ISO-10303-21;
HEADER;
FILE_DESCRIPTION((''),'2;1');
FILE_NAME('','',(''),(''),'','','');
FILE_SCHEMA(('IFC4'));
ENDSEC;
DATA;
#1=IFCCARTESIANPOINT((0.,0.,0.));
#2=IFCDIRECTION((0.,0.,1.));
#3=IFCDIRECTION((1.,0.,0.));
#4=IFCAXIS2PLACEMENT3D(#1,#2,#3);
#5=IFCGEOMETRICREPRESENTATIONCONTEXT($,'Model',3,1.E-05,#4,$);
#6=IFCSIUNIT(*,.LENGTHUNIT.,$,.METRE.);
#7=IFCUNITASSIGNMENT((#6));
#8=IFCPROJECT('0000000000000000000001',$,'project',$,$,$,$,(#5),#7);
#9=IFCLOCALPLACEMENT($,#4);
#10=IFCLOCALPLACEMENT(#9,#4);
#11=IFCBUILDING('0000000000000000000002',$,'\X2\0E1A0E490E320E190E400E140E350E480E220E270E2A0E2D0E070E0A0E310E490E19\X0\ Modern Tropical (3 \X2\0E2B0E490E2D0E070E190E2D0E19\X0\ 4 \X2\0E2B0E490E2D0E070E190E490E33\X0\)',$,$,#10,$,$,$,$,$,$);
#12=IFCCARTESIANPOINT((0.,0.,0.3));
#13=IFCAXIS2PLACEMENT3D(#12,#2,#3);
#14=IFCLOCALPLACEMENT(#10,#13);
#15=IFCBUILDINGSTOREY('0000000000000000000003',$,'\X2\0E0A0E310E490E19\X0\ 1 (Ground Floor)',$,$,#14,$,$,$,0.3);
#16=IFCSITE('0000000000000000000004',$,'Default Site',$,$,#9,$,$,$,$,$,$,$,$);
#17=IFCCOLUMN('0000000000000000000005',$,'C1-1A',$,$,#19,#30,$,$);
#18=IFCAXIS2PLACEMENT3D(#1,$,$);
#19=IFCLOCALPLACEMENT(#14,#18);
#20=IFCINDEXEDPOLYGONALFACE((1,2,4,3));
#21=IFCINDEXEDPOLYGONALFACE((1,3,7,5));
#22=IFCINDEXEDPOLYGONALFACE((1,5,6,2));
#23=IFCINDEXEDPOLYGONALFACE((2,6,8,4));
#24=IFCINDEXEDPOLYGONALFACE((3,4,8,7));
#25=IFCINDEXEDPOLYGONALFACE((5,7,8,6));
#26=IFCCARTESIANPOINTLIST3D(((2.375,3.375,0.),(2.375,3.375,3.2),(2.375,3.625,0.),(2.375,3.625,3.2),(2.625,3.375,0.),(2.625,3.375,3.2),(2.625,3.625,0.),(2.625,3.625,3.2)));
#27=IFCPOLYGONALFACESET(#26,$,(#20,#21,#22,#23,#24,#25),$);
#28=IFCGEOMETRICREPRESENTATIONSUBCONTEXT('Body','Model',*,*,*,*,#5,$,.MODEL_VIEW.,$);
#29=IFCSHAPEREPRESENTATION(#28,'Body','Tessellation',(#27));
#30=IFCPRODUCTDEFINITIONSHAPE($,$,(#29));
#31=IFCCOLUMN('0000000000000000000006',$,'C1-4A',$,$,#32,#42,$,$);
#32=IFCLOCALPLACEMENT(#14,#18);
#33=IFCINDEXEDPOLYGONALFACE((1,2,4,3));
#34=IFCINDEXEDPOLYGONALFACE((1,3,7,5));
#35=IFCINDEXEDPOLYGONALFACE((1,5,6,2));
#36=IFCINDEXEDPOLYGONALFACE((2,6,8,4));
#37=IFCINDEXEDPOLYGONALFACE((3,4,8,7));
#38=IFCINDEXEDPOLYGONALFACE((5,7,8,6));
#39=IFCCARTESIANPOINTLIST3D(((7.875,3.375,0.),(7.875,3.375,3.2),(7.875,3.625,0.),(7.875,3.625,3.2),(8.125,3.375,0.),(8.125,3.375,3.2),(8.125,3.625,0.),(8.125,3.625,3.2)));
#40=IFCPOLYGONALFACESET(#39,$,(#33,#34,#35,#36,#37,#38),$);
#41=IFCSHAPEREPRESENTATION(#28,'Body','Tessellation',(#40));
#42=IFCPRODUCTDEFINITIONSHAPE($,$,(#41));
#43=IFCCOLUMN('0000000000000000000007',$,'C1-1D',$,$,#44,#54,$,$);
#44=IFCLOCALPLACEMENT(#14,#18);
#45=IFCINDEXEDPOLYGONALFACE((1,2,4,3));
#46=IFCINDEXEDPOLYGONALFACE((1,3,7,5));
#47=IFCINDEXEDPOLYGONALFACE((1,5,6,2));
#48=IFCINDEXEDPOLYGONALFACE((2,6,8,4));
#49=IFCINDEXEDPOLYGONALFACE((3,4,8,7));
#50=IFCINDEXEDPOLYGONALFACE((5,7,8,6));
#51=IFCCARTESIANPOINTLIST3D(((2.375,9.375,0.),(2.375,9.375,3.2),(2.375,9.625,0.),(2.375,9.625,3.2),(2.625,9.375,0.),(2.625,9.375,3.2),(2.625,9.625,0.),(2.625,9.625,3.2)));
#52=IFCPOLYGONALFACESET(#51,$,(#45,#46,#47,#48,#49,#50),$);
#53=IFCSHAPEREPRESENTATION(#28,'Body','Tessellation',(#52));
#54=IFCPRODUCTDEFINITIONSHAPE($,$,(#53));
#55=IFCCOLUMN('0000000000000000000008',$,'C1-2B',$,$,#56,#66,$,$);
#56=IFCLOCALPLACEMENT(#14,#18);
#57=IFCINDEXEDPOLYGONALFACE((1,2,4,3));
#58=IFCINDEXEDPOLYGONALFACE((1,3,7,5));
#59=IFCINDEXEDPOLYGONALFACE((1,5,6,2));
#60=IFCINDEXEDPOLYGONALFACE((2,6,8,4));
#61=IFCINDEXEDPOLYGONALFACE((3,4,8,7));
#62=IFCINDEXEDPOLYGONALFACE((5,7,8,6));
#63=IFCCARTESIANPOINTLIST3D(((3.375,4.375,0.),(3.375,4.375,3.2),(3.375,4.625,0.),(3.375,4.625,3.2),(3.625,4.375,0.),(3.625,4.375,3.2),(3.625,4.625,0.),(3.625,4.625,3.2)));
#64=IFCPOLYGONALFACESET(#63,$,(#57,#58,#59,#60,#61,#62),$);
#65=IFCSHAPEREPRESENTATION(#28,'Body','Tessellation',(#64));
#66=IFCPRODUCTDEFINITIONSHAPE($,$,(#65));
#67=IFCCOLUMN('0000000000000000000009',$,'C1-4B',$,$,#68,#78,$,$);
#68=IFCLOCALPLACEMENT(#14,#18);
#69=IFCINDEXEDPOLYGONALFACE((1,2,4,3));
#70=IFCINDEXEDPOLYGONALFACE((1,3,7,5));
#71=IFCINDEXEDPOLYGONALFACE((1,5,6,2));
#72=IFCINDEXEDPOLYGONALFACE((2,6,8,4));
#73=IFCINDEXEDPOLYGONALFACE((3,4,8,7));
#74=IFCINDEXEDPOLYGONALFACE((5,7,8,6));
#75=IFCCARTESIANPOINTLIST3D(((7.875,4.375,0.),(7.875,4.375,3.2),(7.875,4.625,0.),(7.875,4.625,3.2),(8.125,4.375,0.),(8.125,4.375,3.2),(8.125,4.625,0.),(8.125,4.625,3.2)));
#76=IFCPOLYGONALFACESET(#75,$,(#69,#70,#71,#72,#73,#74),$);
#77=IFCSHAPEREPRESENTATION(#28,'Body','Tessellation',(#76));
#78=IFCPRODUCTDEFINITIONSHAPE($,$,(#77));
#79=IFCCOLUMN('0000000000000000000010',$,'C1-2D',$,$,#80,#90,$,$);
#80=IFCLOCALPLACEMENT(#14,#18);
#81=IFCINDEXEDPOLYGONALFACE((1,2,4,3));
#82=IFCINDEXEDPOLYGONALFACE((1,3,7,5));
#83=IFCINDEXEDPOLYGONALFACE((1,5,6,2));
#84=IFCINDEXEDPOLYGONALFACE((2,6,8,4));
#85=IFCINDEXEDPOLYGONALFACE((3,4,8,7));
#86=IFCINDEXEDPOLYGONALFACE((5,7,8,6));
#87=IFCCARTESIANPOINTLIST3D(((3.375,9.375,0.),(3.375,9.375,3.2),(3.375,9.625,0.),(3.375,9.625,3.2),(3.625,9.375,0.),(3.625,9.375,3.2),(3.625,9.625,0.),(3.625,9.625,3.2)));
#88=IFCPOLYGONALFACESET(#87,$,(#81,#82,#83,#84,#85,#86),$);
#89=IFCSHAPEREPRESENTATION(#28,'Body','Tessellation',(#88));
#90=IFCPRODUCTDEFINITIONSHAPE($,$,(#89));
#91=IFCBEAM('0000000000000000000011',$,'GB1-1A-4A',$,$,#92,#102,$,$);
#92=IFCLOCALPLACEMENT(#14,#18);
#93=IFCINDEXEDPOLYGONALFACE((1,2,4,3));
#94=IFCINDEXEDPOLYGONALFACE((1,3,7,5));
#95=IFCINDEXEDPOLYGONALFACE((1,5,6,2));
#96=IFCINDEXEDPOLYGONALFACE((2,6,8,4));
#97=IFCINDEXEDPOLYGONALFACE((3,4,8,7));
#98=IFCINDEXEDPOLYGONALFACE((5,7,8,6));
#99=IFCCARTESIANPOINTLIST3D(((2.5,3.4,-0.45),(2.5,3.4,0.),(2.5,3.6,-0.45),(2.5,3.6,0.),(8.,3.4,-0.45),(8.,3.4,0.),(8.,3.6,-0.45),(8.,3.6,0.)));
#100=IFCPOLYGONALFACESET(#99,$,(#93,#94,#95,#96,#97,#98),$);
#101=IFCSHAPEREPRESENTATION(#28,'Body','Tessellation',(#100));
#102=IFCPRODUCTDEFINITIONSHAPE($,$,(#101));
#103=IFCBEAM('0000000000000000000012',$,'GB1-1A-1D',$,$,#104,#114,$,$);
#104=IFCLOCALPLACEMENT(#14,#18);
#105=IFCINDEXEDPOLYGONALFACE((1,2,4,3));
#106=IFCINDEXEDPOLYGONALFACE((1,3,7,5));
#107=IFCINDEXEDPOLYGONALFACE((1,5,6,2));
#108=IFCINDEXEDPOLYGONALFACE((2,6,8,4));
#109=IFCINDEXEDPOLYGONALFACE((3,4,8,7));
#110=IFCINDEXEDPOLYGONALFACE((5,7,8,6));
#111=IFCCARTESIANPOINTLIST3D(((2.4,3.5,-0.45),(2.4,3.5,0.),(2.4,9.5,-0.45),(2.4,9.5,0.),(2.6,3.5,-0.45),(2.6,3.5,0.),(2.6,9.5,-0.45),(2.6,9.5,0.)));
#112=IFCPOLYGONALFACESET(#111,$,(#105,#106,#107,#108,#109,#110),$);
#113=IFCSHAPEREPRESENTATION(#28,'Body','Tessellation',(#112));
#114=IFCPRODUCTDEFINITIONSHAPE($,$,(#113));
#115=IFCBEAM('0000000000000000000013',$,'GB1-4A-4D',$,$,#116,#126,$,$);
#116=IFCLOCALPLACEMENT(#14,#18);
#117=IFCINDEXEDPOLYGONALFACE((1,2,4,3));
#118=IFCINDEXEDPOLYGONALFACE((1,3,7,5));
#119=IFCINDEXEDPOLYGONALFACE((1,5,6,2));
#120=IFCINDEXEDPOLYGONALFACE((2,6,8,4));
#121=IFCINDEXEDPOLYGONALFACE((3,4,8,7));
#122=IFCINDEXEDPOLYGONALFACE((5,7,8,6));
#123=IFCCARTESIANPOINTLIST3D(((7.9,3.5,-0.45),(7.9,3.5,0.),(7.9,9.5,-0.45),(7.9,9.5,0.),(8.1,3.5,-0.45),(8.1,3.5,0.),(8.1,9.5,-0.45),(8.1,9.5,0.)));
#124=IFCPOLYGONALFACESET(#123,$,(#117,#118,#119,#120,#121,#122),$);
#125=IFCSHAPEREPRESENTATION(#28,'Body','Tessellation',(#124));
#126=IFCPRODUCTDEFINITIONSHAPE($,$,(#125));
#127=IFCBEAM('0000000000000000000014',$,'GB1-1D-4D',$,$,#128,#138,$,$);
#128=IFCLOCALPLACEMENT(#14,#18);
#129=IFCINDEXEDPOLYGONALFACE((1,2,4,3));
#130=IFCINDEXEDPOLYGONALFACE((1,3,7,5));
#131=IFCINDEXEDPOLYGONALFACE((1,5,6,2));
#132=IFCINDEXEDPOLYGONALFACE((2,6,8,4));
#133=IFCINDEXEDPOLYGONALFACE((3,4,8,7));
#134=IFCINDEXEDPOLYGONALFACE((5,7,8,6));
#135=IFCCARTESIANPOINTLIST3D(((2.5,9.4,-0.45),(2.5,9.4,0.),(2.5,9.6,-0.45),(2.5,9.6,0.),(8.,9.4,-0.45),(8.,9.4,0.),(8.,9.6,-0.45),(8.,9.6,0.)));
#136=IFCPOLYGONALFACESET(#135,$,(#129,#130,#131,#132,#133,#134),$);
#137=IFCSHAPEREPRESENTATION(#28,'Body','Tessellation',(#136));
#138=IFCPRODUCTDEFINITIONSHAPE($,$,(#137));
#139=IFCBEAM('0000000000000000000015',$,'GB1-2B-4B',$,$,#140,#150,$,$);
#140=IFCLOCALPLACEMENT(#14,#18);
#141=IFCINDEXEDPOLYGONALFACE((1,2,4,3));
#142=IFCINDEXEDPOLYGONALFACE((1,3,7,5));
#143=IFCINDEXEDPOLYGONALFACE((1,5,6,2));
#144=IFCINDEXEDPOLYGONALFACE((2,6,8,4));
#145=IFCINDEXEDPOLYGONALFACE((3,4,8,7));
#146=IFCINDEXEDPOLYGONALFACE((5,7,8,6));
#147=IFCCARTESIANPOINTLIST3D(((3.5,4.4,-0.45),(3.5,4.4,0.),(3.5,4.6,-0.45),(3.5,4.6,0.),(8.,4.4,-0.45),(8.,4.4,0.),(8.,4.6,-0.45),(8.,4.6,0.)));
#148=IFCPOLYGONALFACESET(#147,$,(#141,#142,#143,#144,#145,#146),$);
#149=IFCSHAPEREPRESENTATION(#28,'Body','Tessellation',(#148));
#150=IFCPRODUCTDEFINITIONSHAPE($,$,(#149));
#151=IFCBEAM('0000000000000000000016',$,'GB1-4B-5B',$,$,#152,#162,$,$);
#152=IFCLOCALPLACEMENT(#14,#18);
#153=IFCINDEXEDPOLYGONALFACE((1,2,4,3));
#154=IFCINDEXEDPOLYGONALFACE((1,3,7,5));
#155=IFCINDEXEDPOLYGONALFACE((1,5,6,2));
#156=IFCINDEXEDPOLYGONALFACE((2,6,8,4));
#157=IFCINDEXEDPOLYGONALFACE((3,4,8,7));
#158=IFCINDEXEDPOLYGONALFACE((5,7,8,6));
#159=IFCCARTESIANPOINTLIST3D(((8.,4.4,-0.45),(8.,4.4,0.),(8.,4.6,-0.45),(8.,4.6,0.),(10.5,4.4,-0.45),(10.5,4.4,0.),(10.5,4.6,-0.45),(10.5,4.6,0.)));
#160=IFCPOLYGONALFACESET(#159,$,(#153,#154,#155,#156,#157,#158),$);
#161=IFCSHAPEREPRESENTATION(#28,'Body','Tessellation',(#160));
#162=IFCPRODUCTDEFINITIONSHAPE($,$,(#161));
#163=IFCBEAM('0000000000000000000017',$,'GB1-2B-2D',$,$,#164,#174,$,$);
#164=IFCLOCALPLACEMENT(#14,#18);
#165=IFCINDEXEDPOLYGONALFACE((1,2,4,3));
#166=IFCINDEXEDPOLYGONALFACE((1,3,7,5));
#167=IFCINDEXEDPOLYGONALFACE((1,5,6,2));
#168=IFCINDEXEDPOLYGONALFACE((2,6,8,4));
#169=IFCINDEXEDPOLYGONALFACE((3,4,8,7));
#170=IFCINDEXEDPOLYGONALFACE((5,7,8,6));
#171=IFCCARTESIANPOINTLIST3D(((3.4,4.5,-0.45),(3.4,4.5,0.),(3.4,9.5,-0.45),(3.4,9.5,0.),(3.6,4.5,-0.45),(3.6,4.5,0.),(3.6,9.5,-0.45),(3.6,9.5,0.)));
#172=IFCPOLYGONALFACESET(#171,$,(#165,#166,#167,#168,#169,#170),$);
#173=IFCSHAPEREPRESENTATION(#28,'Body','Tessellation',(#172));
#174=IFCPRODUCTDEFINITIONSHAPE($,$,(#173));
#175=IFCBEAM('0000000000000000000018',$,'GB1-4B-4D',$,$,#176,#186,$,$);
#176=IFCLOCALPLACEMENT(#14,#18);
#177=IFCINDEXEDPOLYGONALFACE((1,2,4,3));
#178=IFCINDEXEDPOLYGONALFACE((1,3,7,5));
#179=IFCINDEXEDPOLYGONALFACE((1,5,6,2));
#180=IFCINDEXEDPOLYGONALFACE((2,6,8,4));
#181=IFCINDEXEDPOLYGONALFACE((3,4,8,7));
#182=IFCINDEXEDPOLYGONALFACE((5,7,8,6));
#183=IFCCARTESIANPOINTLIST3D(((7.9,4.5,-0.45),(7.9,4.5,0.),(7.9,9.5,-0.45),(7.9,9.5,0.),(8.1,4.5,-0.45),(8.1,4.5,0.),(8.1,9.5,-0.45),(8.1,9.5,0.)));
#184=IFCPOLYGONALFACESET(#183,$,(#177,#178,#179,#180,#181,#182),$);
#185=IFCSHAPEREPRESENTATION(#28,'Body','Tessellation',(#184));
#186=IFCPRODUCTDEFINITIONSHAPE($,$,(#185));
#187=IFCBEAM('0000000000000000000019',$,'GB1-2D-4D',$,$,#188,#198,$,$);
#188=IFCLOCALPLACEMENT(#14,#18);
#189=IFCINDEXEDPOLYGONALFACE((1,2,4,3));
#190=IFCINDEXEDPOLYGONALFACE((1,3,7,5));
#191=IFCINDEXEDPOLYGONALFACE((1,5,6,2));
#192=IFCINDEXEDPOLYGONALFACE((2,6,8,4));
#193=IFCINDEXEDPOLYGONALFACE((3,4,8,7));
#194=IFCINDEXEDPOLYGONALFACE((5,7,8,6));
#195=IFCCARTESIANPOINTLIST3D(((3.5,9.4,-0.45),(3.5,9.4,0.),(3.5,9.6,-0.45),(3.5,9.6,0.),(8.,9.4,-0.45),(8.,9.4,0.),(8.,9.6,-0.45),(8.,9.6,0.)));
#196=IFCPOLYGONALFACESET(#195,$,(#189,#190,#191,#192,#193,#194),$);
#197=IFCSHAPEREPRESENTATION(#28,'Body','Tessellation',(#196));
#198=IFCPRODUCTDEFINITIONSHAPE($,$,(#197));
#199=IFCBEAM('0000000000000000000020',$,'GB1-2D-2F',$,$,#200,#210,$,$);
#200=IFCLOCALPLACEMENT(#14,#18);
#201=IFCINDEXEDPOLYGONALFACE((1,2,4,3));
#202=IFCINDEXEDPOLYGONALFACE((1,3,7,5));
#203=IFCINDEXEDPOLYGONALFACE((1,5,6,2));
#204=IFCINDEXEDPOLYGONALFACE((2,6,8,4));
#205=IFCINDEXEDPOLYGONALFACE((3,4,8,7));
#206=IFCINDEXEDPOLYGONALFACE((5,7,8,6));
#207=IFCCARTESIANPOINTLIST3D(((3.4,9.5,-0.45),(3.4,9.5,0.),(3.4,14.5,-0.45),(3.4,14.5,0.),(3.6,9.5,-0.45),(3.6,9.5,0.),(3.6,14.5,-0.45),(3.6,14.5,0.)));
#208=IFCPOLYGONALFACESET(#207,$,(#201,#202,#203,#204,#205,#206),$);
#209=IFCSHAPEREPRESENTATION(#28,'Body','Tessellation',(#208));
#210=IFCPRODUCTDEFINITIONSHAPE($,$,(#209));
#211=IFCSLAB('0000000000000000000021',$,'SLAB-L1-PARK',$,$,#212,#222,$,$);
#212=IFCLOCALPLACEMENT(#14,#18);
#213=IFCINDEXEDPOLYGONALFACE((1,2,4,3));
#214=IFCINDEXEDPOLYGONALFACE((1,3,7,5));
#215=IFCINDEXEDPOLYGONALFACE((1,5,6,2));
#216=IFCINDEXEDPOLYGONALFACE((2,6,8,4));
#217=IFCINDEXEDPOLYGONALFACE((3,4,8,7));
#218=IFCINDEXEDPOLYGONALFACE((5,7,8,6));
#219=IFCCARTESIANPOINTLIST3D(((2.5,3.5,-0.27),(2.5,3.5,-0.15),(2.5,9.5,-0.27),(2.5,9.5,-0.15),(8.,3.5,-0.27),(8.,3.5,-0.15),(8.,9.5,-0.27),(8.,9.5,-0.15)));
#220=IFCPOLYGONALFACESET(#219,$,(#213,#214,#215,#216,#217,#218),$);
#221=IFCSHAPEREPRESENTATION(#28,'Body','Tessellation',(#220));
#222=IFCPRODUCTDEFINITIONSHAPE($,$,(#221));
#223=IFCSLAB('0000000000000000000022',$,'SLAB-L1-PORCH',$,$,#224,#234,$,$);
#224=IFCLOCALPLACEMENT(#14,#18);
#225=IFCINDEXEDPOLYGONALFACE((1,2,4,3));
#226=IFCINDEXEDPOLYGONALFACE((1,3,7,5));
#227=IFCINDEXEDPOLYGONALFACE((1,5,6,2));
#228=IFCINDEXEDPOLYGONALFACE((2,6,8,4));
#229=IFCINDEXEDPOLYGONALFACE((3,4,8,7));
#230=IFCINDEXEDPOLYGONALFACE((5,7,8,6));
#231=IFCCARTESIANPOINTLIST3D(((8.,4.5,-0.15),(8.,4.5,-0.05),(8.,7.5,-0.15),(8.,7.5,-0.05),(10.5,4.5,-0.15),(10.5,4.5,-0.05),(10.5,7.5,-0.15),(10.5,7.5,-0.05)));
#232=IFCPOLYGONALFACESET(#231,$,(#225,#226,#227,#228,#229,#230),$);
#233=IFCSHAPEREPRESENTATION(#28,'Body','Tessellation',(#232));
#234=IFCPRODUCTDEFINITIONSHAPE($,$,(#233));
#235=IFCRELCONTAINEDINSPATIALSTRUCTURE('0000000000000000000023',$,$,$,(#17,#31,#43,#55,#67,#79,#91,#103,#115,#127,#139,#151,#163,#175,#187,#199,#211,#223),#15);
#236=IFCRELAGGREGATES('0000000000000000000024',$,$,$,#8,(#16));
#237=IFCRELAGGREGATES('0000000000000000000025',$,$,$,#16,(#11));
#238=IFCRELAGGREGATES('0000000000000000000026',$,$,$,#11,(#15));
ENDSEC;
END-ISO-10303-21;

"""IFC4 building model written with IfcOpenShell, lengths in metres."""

from ifc_helpers import new_model, si_unit, frame, origin_with_axes, origin_2d, place, context, subcontext, project, spatial, polyline, rectangle, outline, extrude, element, save


model = new_model("IFC4")

# Units and contexts
model_context = context("Model", 3, precision=1e-05, world=origin_with_axes())
body_context = subcontext(model_context, "Body", "Model", "MODEL_VIEW")
ifc_project = project(units=[si_unit("LENGTHUNIT", "METRE")], contexts=[model_context])

# Site, building, storey
site_placement = place(None, origin_with_axes())
site = spatial("IfcSite", under=ifc_project, at=site_placement, Name="Default Site")
building_placement = place(site_placement, origin_with_axes())
building = spatial("IfcBuilding", under=site, at=building_placement, Name="บ้านเดี่ยวสองชั้น Modern Tropical (3 ห้องนอน 4 ห้องน้ำ)")
storey_placement = place(building_placement, frame((0.0, 0.0, 0.3), z_axis=(0.0, 0.0, 1.0), x_axis=(1.0, 0.0, 0.0)))
storey = spatial("IfcBuildingStorey", under=building, at=storey_placement, Name="ชั้น 1 (Ground Floor)", Elevation=0.3)

# Columns
for number, where, z_axis, x_axis, name in (
    (1, (2.5, 3.5, 0.0), (0.0, 0.0, 1.0), (1.0, 0.0, 0.0), "C1-1A"),
    (2, (8.0, 3.5, 0.0), (0.0, 0.0, 1.0), (1.0, 0.0, 0.0), "C1-4A"),
    (3, (2.5, 9.5, 0.0), (0.0, 0.0, 1.0), (1.0, 0.0, 0.0), "C1-1D"),
    (4, (3.5, 4.5, 0.0), (0.0, 0.0, 1.0), (1.0, 0.0, 0.0), "C1-2B"),
    (5, (8.0, 4.5, 0.0), (0.0, 0.0, 1.0), (1.0, 0.0, 0.0), "C1-4B"),
    (6, (3.5, 9.5, 0.0), (0.0, 0.0, 1.0), (1.0, 0.0, 0.0), "C1-2D"),
):
    element("IfcColumn", number, at=place(storey_placement, frame(where, z_axis=z_axis, x_axis=x_axis)), inside=storey, Name=name, context=body_context, shape_type="SweptSolid", body=[
        extrude(rectangle(XDim=0.25, YDim=0.25, at=origin_2d()), origin_with_axes(), (0.0, 0.0, 1.0), 3.2),
    ])

# Beams
beam_1_placement = place(storey_placement, frame((2.5, 3.5, -0.225), z_axis=(1.0, 0.0, 0.0), x_axis=(0.0, 1.0, 0.0)))
element("IfcBeam", 7, at=beam_1_placement, inside=storey, Name="GB1-1A-4A", context=body_context, shape_type="SweptSolid", body=[
    extrude(rectangle(XDim=0.2, YDim=0.45, at=origin_2d()), origin_with_axes(), (0.0, 0.0, 1.0), 5.5),
])
for number, where, z_axis, x_axis, name in (
    (8, (2.5, 3.5, -0.225), (0.0, 1.0, 0.0), (-1.0, 0.0, 0.0), "GB1-1A-1D"),
    (9, (8.0, 3.5, -0.225), (0.0, 1.0, 0.0), (-1.0, 0.0, 0.0), "GB1-4A-4D"),
):
    element("IfcBeam", number, at=place(storey_placement, frame(where, z_axis=z_axis, x_axis=x_axis)), inside=storey, Name=name, context=body_context, shape_type="SweptSolid", body=[
        extrude(rectangle(XDim=0.2, YDim=0.45, at=origin_2d()), origin_with_axes(), (0.0, 0.0, 1.0), 6.0),
    ])
beam_2_placement = place(storey_placement, frame((2.5, 9.5, -0.225), z_axis=(1.0, 0.0, 0.0), x_axis=(0.0, 1.0, 0.0)))
element("IfcBeam", 10, at=beam_2_placement, inside=storey, Name="GB1-1D-4D", context=body_context, shape_type="SweptSolid", body=[
    extrude(rectangle(XDim=0.2, YDim=0.45, at=origin_2d()), origin_with_axes(), (0.0, 0.0, 1.0), 5.5),
])
beam_3_placement = place(storey_placement, frame((3.5, 4.5, -0.225), z_axis=(1.0, 0.0, 0.0), x_axis=(0.0, 1.0, 0.0)))
element("IfcBeam", 11, at=beam_3_placement, inside=storey, Name="GB1-2B-4B", context=body_context, shape_type="SweptSolid", body=[
    extrude(rectangle(XDim=0.2, YDim=0.45, at=origin_2d()), origin_with_axes(), (0.0, 0.0, 1.0), 4.5),
])
beam_4_placement = place(storey_placement, frame((8.0, 4.5, -0.225), z_axis=(1.0, 0.0, 0.0), x_axis=(0.0, 1.0, 0.0)))
element("IfcBeam", 12, at=beam_4_placement, inside=storey, Name="GB1-4B-5B", context=body_context, shape_type="SweptSolid", body=[
    extrude(rectangle(XDim=0.2, YDim=0.45, at=origin_2d()), origin_with_axes(), (0.0, 0.0, 1.0), 2.5),
])
for number, where, z_axis, x_axis, name in (
    (13, (3.5, 4.5, -0.225), (0.0, 1.0, 0.0), (-1.0, 0.0, 0.0), "GB1-2B-2D"),
    (14, (8.0, 4.5, -0.225), (0.0, 1.0, 0.0), (-1.0, 0.0, 0.0), "GB1-4B-4D"),
):
    element("IfcBeam", number, at=place(storey_placement, frame(where, z_axis=z_axis, x_axis=x_axis)), inside=storey, Name=name, context=body_context, shape_type="SweptSolid", body=[
        extrude(rectangle(XDim=0.2, YDim=0.45, at=origin_2d()), origin_with_axes(), (0.0, 0.0, 1.0), 5.0),
    ])
beam_5_placement = place(storey_placement, frame((3.5, 9.5, -0.225), z_axis=(1.0, 0.0, 0.0), x_axis=(0.0, 1.0, 0.0)))
element("IfcBeam", 15, at=beam_5_placement, inside=storey, Name="GB1-2D-4D", context=body_context, shape_type="SweptSolid", body=[
    extrude(rectangle(XDim=0.2, YDim=0.45, at=origin_2d()), origin_with_axes(), (0.0, 0.0, 1.0), 4.5),
])
beam_6_placement = place(storey_placement, frame((3.5, 9.5, -0.225), z_axis=(0.0, 1.0, 0.0), x_axis=(-1.0, 0.0, 0.0)))
element("IfcBeam", 16, at=beam_6_placement, inside=storey, Name="GB1-2D-2F", context=body_context, shape_type="SweptSolid", body=[
    extrude(rectangle(XDim=0.2, YDim=0.45, at=origin_2d()), origin_with_axes(), (0.0, 0.0, 1.0), 5.0),
])

# Slabs
slab_1_placement = place(storey_placement, frame((0.0, 0.0, -0.27), z_axis=(0.0, 0.0, 1.0), x_axis=(1.0, 0.0, 0.0)))
element("IfcSlab", 17, at=slab_1_placement, inside=storey, Name="SLAB-L1-PARK", context=body_context, shape_type="SweptSolid", body=[
    extrude(outline(polyline([(2.5, 3.5), (8.0, 3.5), (8.0, 9.5), (2.5, 9.5), (2.5, 3.5)])), origin_with_axes(), (0.0, 0.0, 1.0), 0.12),
])
slab_2_placement = place(storey_placement, frame((0.0, 0.0, -0.15), z_axis=(0.0, 0.0, 1.0), x_axis=(1.0, 0.0, 0.0)))
element("IfcSlab", 18, at=slab_2_placement, inside=storey, Name="SLAB-L1-PORCH", context=body_context, shape_type="SweptSolid", body=[
    extrude(outline(polyline([(8.0, 4.5), (10.5, 4.5), (10.5, 7.5), (8.0, 7.5), (8.0, 4.5)])), origin_with_axes(), (0.0, 0.0, 1.0), 0.1),
])

save(model, "model.ifc")
